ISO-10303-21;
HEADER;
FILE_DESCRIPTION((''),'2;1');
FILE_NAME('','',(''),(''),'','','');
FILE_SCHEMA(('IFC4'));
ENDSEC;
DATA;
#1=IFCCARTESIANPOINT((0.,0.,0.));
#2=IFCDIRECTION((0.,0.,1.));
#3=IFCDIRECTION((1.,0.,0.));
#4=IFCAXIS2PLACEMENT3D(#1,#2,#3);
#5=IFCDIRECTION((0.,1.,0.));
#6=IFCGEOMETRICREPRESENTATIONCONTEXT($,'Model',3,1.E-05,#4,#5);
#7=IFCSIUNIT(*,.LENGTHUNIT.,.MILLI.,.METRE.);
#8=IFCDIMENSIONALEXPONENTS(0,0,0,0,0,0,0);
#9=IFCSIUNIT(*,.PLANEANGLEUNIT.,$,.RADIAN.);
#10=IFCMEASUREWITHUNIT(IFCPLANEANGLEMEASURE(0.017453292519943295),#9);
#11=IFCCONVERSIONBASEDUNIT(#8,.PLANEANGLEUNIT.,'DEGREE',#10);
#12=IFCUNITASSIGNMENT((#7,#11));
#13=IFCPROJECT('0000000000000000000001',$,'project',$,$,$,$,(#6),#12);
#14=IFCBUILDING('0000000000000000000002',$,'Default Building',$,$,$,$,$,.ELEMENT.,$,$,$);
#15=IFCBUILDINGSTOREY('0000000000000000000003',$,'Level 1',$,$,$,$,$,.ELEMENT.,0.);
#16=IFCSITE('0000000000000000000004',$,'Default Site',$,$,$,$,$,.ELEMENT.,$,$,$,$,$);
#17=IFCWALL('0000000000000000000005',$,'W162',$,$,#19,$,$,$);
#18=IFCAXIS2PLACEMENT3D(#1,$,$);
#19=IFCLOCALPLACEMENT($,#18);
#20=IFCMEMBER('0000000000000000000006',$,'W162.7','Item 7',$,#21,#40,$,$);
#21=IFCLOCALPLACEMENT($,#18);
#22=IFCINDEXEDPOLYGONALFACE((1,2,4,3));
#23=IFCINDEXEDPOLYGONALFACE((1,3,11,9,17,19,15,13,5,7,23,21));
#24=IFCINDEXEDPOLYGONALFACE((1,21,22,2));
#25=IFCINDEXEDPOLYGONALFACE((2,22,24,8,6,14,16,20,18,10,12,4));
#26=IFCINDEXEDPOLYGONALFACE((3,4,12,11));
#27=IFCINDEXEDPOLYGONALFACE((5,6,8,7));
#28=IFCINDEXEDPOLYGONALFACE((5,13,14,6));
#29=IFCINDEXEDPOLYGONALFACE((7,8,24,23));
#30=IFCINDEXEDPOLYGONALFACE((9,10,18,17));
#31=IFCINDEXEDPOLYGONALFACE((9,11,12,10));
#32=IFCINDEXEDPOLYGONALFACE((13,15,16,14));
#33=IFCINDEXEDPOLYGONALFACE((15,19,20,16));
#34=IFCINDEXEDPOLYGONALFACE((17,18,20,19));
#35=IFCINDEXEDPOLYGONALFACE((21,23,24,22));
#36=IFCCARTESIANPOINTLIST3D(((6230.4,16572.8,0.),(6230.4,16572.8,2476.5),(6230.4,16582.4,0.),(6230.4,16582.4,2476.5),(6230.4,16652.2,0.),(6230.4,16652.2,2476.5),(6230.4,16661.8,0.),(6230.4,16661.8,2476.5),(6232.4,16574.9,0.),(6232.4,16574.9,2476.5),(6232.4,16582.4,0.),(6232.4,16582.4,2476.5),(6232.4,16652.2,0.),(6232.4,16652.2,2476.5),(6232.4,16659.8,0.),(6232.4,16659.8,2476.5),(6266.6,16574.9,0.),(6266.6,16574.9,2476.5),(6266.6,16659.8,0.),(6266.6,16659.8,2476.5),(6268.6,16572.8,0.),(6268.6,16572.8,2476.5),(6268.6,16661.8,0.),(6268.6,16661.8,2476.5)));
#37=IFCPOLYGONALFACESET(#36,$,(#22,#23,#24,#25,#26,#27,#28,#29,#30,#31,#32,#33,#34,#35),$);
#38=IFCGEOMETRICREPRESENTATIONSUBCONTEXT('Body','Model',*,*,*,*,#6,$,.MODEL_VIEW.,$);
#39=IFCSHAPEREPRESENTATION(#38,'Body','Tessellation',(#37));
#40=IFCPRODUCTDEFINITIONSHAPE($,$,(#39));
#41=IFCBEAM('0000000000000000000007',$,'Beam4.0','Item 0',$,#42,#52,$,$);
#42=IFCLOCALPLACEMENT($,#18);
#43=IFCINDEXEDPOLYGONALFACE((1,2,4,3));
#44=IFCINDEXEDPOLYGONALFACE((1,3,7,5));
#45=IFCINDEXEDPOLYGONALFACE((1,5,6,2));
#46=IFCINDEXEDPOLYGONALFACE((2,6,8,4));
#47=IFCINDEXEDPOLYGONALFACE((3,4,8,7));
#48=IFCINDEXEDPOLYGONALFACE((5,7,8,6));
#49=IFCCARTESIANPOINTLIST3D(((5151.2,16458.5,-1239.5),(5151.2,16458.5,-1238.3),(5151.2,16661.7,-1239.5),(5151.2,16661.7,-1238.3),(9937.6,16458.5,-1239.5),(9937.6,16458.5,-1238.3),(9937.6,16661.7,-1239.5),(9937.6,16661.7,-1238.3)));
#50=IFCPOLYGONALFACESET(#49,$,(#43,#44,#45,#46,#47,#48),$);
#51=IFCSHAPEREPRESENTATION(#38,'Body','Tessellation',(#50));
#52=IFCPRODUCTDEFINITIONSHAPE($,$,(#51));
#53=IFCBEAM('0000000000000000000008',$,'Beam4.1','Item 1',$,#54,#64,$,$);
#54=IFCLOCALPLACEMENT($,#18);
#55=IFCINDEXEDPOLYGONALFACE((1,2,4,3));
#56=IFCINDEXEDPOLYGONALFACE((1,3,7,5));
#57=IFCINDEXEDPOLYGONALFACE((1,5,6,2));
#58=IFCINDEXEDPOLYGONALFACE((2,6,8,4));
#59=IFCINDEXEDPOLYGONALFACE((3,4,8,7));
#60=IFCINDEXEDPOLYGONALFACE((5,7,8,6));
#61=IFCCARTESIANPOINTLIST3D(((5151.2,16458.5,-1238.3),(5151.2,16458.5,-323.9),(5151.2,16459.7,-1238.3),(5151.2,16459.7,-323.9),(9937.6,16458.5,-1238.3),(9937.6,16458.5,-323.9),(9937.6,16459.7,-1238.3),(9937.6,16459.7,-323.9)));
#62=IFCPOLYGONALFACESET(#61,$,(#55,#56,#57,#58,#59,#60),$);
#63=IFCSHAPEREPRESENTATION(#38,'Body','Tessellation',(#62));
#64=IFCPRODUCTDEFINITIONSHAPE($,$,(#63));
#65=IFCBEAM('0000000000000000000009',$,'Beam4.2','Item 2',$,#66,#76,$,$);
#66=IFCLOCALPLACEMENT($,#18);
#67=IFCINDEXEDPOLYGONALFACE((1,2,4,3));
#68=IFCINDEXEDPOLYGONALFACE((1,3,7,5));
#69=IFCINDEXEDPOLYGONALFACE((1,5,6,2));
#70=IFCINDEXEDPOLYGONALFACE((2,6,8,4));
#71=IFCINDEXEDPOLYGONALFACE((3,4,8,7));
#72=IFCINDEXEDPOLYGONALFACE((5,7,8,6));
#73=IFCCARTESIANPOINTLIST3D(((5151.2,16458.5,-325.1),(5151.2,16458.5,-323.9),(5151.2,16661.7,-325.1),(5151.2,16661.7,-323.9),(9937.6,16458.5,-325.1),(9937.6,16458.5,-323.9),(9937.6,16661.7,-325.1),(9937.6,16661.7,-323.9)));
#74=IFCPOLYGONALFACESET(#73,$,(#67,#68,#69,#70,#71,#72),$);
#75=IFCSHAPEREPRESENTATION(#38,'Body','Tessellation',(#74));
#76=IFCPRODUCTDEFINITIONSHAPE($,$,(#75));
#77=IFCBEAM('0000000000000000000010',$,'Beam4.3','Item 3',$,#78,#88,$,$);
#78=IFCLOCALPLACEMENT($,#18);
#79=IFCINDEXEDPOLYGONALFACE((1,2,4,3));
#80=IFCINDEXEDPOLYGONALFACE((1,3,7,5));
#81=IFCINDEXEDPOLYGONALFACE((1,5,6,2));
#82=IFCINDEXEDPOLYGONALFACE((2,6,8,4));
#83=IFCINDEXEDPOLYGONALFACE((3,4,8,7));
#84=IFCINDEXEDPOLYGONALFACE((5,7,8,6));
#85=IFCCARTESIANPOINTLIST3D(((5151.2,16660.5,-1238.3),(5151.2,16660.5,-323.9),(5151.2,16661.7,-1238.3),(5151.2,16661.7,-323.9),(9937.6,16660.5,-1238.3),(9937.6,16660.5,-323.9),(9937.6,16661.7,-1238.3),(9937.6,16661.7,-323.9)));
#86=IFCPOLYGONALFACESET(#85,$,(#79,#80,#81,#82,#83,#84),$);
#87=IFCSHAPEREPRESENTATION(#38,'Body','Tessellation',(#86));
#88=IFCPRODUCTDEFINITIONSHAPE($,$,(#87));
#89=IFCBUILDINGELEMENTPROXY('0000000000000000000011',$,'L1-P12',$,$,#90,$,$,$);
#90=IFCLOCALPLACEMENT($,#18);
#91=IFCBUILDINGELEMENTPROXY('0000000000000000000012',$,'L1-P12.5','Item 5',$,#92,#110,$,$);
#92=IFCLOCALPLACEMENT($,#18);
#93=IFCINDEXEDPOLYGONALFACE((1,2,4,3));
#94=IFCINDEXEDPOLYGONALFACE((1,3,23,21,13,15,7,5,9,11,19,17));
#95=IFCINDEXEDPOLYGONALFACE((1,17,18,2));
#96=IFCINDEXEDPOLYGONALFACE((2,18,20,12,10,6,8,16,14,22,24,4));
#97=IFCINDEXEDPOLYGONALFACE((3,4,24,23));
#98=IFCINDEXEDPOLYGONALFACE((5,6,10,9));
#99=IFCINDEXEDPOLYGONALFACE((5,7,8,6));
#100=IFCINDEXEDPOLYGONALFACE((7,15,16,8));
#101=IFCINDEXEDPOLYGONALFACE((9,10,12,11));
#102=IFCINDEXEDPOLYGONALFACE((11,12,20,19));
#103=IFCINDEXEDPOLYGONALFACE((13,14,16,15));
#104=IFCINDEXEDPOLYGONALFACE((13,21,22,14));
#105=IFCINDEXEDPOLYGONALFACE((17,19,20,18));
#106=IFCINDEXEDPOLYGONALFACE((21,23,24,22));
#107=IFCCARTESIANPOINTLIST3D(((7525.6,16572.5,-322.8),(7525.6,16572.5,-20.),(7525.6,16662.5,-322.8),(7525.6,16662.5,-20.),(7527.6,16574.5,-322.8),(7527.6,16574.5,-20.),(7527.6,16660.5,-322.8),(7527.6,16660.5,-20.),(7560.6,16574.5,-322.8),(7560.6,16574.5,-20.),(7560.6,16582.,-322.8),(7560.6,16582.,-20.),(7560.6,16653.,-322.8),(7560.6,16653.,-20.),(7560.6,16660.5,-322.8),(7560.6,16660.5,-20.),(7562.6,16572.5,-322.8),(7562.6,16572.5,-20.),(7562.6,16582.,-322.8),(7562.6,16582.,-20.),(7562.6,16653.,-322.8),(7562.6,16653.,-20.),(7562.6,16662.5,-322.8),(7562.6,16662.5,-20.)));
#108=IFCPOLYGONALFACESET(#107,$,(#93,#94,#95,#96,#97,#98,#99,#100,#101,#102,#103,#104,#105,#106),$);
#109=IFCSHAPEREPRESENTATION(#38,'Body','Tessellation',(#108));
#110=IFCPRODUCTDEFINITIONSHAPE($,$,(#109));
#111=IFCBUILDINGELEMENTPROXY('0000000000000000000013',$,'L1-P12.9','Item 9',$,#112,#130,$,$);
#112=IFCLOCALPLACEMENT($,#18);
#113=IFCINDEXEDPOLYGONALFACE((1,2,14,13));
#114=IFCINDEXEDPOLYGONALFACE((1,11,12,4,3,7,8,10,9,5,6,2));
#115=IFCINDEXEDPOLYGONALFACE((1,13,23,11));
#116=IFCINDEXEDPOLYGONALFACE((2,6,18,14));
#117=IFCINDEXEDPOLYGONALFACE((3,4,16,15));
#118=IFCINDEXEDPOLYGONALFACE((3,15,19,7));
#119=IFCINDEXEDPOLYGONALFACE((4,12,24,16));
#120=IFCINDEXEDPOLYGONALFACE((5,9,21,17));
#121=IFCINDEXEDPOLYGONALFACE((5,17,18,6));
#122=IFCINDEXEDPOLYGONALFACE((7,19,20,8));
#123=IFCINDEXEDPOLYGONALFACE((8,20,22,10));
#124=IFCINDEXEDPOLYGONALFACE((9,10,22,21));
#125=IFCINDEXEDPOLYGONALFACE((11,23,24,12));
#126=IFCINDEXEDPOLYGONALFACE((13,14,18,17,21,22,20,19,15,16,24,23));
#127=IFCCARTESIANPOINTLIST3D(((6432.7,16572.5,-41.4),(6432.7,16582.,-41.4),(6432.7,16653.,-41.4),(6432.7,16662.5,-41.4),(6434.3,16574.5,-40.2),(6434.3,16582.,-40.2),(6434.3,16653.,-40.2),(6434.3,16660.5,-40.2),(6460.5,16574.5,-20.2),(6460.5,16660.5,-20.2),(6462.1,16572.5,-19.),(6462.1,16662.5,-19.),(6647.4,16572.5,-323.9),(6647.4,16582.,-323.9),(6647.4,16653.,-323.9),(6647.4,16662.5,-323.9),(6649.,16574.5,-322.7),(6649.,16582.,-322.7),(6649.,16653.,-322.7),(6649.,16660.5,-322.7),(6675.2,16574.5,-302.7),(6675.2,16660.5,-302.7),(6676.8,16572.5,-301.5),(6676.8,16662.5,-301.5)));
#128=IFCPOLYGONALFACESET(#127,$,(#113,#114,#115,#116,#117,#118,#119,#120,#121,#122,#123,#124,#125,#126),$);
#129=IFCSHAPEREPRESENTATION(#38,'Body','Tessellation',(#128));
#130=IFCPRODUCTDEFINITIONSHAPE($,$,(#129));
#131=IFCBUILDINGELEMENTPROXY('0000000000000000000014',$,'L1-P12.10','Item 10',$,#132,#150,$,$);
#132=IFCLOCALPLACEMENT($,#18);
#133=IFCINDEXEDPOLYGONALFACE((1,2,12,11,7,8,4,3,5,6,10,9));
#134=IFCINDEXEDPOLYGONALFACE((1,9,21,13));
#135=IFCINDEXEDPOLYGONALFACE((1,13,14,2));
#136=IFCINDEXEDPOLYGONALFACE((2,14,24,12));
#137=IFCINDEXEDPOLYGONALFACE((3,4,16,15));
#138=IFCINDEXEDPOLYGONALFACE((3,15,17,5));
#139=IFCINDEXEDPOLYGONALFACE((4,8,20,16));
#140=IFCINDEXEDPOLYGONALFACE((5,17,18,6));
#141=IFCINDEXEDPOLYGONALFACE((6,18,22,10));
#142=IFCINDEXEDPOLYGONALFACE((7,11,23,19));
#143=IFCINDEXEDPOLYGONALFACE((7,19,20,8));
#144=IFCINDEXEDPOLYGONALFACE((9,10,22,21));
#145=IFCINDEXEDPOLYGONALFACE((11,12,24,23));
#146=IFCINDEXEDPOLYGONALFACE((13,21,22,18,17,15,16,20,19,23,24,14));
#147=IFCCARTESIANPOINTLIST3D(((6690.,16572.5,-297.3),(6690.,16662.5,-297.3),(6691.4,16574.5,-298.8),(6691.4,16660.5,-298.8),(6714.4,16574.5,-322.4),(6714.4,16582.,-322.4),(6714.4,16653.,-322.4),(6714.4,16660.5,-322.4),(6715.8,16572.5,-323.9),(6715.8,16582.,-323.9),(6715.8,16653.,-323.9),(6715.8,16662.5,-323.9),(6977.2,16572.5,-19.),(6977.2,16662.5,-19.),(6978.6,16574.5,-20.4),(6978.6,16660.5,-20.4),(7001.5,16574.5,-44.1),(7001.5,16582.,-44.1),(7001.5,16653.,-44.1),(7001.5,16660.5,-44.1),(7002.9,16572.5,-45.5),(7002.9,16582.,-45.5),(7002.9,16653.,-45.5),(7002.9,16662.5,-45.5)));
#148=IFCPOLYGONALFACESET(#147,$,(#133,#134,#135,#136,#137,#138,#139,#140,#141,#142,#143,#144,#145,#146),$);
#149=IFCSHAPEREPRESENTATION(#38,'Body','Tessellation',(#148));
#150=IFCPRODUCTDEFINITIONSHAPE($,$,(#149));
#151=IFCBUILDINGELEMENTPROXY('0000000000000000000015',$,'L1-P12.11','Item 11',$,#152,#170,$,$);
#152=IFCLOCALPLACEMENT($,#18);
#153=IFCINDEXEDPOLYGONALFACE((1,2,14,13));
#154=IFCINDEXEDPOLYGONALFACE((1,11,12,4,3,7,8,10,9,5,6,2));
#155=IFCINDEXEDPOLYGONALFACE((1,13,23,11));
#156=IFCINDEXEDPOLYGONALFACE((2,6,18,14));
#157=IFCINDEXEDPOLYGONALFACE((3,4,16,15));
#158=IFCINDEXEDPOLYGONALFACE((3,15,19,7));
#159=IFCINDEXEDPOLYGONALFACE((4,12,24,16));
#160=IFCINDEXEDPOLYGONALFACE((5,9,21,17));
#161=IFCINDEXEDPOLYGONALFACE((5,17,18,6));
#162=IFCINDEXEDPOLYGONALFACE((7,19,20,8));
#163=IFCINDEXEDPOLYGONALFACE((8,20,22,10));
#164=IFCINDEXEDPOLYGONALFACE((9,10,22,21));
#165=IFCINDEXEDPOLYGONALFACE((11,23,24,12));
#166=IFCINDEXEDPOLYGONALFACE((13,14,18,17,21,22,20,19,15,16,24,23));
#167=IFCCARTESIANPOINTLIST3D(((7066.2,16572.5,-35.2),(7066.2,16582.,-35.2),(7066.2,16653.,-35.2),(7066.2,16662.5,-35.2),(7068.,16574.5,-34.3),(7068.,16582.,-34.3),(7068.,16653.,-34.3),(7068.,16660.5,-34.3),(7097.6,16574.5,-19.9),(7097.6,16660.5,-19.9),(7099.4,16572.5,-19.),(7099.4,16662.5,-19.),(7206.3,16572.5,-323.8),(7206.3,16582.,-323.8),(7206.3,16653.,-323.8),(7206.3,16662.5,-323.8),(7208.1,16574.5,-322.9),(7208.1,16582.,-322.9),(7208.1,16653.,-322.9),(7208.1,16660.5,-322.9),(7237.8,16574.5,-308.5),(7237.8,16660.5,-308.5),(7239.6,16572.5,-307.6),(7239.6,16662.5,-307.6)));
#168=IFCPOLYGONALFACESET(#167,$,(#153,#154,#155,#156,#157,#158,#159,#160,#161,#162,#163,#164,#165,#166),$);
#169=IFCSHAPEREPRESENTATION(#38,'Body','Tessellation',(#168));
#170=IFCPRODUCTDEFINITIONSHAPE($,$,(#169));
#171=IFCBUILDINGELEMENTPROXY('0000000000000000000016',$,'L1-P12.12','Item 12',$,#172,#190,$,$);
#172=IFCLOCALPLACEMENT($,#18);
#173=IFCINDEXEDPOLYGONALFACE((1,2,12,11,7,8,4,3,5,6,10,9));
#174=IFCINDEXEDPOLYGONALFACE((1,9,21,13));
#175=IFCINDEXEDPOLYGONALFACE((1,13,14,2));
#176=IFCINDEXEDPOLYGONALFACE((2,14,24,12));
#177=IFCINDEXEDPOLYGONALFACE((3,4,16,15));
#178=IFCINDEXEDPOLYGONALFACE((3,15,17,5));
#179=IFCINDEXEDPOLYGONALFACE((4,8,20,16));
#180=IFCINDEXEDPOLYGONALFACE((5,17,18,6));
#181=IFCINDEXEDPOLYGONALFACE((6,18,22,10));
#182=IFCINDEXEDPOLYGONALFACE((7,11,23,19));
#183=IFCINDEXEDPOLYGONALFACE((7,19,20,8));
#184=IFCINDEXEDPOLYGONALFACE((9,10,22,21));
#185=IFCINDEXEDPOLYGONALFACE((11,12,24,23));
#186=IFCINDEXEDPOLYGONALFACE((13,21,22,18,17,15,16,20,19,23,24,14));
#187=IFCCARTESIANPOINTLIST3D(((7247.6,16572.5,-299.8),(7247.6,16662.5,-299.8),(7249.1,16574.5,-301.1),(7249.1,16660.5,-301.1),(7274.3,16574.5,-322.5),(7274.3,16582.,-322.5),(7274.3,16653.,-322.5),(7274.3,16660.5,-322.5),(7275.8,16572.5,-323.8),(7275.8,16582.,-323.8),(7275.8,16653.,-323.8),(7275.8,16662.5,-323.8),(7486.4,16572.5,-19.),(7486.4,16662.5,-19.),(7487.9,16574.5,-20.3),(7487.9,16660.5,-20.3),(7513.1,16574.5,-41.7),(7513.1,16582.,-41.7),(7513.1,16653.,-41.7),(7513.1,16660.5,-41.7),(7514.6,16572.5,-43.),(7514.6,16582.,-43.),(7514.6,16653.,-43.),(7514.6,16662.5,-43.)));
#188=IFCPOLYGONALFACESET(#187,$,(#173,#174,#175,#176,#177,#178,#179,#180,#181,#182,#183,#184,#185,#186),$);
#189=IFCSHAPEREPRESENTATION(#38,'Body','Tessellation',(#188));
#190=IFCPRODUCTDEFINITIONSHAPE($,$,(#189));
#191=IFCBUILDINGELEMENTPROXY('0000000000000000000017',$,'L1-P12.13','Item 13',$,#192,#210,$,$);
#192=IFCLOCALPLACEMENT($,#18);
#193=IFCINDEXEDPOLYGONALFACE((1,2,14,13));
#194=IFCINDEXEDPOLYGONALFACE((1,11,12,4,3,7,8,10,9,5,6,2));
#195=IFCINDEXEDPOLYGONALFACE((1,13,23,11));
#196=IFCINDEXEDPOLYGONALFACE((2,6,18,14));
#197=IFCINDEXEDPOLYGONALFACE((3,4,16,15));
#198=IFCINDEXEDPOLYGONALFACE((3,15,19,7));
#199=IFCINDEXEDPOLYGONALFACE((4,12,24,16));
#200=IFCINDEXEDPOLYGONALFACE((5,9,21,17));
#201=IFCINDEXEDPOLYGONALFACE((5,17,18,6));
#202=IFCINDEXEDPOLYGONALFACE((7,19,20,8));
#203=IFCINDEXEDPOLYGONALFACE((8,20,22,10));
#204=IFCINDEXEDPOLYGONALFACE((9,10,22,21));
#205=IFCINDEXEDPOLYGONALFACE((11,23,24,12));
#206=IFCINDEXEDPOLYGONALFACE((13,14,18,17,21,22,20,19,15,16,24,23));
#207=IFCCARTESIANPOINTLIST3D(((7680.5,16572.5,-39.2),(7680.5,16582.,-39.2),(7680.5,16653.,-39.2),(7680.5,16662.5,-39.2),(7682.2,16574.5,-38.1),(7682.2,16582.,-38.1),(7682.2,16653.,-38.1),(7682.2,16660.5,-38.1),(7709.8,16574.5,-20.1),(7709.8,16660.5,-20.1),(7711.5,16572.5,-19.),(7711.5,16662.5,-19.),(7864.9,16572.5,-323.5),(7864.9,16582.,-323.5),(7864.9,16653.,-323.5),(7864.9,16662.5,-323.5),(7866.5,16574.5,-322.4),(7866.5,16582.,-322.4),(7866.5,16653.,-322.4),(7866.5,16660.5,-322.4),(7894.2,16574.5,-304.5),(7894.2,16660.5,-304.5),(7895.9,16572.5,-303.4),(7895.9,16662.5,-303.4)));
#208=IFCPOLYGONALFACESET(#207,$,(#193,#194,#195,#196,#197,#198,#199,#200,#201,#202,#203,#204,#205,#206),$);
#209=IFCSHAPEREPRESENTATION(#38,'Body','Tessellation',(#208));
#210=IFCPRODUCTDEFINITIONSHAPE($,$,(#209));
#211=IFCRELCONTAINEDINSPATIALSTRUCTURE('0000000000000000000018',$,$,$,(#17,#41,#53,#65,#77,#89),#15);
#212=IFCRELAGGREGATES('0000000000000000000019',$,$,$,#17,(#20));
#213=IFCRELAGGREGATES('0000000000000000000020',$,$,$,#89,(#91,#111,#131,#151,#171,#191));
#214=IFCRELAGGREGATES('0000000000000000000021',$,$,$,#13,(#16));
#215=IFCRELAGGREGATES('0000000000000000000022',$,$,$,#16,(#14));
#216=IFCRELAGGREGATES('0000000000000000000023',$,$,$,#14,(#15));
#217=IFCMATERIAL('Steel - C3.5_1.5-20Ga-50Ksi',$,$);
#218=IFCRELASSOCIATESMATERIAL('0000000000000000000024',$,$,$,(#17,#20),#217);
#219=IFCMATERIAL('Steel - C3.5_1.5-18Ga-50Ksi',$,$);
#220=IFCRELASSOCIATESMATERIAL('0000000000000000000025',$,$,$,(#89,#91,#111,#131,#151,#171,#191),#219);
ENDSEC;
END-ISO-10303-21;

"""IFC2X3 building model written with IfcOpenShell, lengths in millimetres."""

from ifc_helpers import new_model, entity, si_unit, converted_unit, direction, frame, origin, origin_with_axes, origin_2d_with_axis, place, context, subcontext, project, spatial, polyline, c_section, outline, extrude, material, element, aggregate, save


model = new_model("IFC2X3")

# Units and contexts
model_context = context("Model", 3, precision=1e-05, world=origin_with_axes(), true_north=direction((0.0, 1.0, 0.0)))
body_context = subcontext(model_context, "Body", "Model", "MODEL_VIEW")
ifc_project = project(units=[si_unit("LENGTHUNIT", "METRE", prefix="MILLI"), converted_unit("PLANEANGLEUNIT", "DEGREE", entity("IfcPlaneAngleMeasure", 0.017453292519943295), si_unit("PLANEANGLEUNIT", "RADIAN"), dimensions=[0, 0, 0, 0, 0, 0, 0])], contexts=[model_context])

# Site, building, storey
site = spatial("IfcSite", under=ifc_project, Name="Default Site", CompositionType="ELEMENT")
building = spatial("IfcBuilding", under=site, Name="Default Building", CompositionType="ELEMENT")
storey = spatial("IfcBuildingStorey", under=building, Name="Level 1", CompositionType="ELEMENT", Elevation=0.0)

# Wall, member
ifc_material_1 = material(Name="Steel - C3.5_1.5-20Ga-50Ksi")
wall = element("IfcWall", 1, inside=storey, material=ifc_material_1, Name="W162")
member_placement = place(None, frame((6249.5, 16617.3, 0.0), z_axis=(0.0, 0.0, 1.0), x_axis=(-1.0, 0.0, 0.0)))
member = element("IfcMember", 2, at=member_placement, material=ifc_material_1, Name="W162.7", Description="Item 7", context=body_context, shape_type="SweptSolid", body=[
    extrude(c_section(Depth=88.9, Width=38.1, WallThickness=2.0, Girth=9.5, at=origin_2d_with_axis()), origin(), (0.0, 0.0, 1.0), 2476.5),
])
aggregate(wall, [member])

# Beams
beam_1_placement = place(None, frame((7544.4, 16560.1, -1238.3), z_axis=(0.0, 0.0, -1.0), x_axis=(1.0, 0.0, 0.0)))
element("IfcBeam", 3, at=beam_1_placement, inside=storey, Name="Beam4.0", Description="Item 0", context=body_context, shape_type="SweptSolid", body=[
    extrude(outline(polyline([(-2393.2, -101.6), (2393.2, -101.6), (2393.2, 101.6), (-2393.2, 101.6), (-2393.2, -101.6)])), origin(), (0.0, 0.0, 1.0), 1.2),
])
beam_2_placement = place(None, frame((7544.4, 16458.5, -781.1), z_axis=(0.0, 1.0, 0.0), x_axis=(1.0, 0.0, 0.0)))
element("IfcBeam", 4, at=beam_2_placement, inside=storey, Name="Beam4.1", Description="Item 1", context=body_context, shape_type="SweptSolid", body=[
    extrude(outline(polyline([(-2393.2, -457.2), (2393.2, -457.2), (2393.2, 457.2), (-2393.2, 457.2), (-2393.2, -457.2)])), origin(), (0.0, 0.0, 1.0), 1.2),
])
beam_3_placement = place(None, frame((7544.4, 16560.1, -323.9), z_axis=(0.0, 0.0, -1.0), x_axis=(1.0, 0.0, 0.0)))
element("IfcBeam", 5, at=beam_3_placement, inside=storey, Name="Beam4.2", Description="Item 2", context=body_context, shape_type="SweptSolid", body=[
    extrude(outline(polyline([(-2393.2, -101.6), (2393.2, -101.6), (2393.2, 101.6), (-2393.2, 101.6), (-2393.2, -101.6)])), origin(), (0.0, 0.0, 1.0), 1.2),
])
beam_4_placement = place(None, frame((7544.4, 16661.7, -781.1), z_axis=(0.0, -1.0, 0.0), x_axis=(-1.0, 0.0, 0.0)))
element("IfcBeam", 6, at=beam_4_placement, inside=storey, Name="Beam4.3", Description="Item 3", context=body_context, shape_type="SweptSolid", body=[
    extrude(outline(polyline([(-2393.2, -457.2), (2393.2, -457.2), (2393.2, 457.2), (-2393.2, 457.2), (-2393.2, -457.2)])), origin(), (0.0, 0.0, 1.0), 1.2),
])

# Building element proxies
ifc_material_2 = material(Name="Steel - C3.5_1.5-18Ga-50Ksi")
proxy_1 = element("IfcBuildingElementProxy", 7, inside=storey, material=ifc_material_2, Name="L1-P12")
proxy_2_placement = place(None, frame((7544.1, 16617.5, -322.8), z_axis=(0.0, 0.0, 1.0), x_axis=(37.0, 0.0, 0.0)))
proxy_2 = element("IfcBuildingElementProxy", 8, at=proxy_2_placement, material=ifc_material_2, Name="L1-P12.5", Description="Item 5", context=body_context, shape_type="SweptSolid", body=[
    extrude(c_section(Depth=90.0, Width=37.0, WallThickness=2.0, Girth=9.5, at=origin_2d_with_axis()), origin(), (0.0, 0.0, 1.0), 302.8),
])
proxy_3_placement = place(None, frame((6447.4, 16617.5, -30.2), z_axis=(0.605, 0.0, -0.796), x_axis=(-29.452, 0.0, -22.396)))
proxy_3 = element("IfcBuildingElementProxy", 9, at=proxy_3_placement, material=ifc_material_2, Name="L1-P12.9", Description="Item 9", context=body_context, shape_type="SweptSolid", body=[
    extrude(c_section(Depth=90.0, Width=37.0, WallThickness=2.0, Girth=9.5, at=origin_2d_with_axis()), origin(), (0.0, 0.0, 1.0), 354.8),
])
proxy_4_placement = place(None, frame((6702.9, 16617.5, -310.6), z_axis=(0.718, 0.0, 0.696), x_axis=(25.741, 0.0, -26.578)))
proxy_4 = element("IfcBuildingElementProxy", 10, at=proxy_4_placement, material=ifc_material_2, Name="L1-P12.10", Description="Item 10", context=body_context, shape_type="SweptSolid", body=[
    extrude(c_section(Depth=90.0, Width=37.0, WallThickness=2.0, Girth=9.5, at=origin_2d_with_axis()), origin(), (0.0, 0.0, 1.0), 399.9),
])
proxy_5_placement = place(None, frame((7082.8, 16617.5, -27.1), z_axis=(0.437, 0.0, -0.9), x_axis=(-33.287, 0.0, -16.154)))
proxy_5 = element("IfcBuildingElementProxy", 11, at=proxy_5_placement, material=ifc_material_2, Name="L1-P12.11", Description="Item 11", context=body_context, shape_type="SweptSolid", body=[
    extrude(c_section(Depth=90.0, Width=37.0, WallThickness=2.0, Girth=9.5, at=origin_2d_with_axis()), origin(), (0.0, 0.0, 1.0), 320.8),
])
proxy_6_placement = place(None, frame((7261.7, 16617.5, -311.8), z_axis=(0.648, 0.0, 0.762), x_axis=(28.188, 0.0, -23.968)))
proxy_6 = element("IfcBuildingElementProxy", 12, at=proxy_6_placement, material=ifc_material_2, Name="L1-P12.12", Description="Item 12", context=body_context, shape_type="SweptSolid", body=[
    extrude(c_section(Depth=90.0, Width=37.0, WallThickness=2.0, Girth=9.5, at=origin_2d_with_axis()), origin(), (0.0, 0.0, 1.0), 368.6),
])
proxy_7_placement = place(None, frame((7696.0, 16617.5, -29.1), z_axis=(0.544, 0.0, -0.839), x_axis=(-31.037, 0.0, -20.142)))
proxy_7 = element("IfcBuildingElementProxy", 13, at=proxy_7_placement, material=ifc_material_2, Name="L1-P12.13", Description="Item 13", context=body_context, shape_type="SweptSolid", body=[
    extrude(c_section(Depth=90.0, Width=37.0, WallThickness=2.0, Girth=9.5, at=origin_2d_with_axis()), origin(), (0.0, 0.0, 1.0), 338.9),
])
aggregate(proxy_1, [proxy_2, proxy_3, proxy_4, proxy_5, proxy_6, proxy_7])

save(model, "model.ifc")
